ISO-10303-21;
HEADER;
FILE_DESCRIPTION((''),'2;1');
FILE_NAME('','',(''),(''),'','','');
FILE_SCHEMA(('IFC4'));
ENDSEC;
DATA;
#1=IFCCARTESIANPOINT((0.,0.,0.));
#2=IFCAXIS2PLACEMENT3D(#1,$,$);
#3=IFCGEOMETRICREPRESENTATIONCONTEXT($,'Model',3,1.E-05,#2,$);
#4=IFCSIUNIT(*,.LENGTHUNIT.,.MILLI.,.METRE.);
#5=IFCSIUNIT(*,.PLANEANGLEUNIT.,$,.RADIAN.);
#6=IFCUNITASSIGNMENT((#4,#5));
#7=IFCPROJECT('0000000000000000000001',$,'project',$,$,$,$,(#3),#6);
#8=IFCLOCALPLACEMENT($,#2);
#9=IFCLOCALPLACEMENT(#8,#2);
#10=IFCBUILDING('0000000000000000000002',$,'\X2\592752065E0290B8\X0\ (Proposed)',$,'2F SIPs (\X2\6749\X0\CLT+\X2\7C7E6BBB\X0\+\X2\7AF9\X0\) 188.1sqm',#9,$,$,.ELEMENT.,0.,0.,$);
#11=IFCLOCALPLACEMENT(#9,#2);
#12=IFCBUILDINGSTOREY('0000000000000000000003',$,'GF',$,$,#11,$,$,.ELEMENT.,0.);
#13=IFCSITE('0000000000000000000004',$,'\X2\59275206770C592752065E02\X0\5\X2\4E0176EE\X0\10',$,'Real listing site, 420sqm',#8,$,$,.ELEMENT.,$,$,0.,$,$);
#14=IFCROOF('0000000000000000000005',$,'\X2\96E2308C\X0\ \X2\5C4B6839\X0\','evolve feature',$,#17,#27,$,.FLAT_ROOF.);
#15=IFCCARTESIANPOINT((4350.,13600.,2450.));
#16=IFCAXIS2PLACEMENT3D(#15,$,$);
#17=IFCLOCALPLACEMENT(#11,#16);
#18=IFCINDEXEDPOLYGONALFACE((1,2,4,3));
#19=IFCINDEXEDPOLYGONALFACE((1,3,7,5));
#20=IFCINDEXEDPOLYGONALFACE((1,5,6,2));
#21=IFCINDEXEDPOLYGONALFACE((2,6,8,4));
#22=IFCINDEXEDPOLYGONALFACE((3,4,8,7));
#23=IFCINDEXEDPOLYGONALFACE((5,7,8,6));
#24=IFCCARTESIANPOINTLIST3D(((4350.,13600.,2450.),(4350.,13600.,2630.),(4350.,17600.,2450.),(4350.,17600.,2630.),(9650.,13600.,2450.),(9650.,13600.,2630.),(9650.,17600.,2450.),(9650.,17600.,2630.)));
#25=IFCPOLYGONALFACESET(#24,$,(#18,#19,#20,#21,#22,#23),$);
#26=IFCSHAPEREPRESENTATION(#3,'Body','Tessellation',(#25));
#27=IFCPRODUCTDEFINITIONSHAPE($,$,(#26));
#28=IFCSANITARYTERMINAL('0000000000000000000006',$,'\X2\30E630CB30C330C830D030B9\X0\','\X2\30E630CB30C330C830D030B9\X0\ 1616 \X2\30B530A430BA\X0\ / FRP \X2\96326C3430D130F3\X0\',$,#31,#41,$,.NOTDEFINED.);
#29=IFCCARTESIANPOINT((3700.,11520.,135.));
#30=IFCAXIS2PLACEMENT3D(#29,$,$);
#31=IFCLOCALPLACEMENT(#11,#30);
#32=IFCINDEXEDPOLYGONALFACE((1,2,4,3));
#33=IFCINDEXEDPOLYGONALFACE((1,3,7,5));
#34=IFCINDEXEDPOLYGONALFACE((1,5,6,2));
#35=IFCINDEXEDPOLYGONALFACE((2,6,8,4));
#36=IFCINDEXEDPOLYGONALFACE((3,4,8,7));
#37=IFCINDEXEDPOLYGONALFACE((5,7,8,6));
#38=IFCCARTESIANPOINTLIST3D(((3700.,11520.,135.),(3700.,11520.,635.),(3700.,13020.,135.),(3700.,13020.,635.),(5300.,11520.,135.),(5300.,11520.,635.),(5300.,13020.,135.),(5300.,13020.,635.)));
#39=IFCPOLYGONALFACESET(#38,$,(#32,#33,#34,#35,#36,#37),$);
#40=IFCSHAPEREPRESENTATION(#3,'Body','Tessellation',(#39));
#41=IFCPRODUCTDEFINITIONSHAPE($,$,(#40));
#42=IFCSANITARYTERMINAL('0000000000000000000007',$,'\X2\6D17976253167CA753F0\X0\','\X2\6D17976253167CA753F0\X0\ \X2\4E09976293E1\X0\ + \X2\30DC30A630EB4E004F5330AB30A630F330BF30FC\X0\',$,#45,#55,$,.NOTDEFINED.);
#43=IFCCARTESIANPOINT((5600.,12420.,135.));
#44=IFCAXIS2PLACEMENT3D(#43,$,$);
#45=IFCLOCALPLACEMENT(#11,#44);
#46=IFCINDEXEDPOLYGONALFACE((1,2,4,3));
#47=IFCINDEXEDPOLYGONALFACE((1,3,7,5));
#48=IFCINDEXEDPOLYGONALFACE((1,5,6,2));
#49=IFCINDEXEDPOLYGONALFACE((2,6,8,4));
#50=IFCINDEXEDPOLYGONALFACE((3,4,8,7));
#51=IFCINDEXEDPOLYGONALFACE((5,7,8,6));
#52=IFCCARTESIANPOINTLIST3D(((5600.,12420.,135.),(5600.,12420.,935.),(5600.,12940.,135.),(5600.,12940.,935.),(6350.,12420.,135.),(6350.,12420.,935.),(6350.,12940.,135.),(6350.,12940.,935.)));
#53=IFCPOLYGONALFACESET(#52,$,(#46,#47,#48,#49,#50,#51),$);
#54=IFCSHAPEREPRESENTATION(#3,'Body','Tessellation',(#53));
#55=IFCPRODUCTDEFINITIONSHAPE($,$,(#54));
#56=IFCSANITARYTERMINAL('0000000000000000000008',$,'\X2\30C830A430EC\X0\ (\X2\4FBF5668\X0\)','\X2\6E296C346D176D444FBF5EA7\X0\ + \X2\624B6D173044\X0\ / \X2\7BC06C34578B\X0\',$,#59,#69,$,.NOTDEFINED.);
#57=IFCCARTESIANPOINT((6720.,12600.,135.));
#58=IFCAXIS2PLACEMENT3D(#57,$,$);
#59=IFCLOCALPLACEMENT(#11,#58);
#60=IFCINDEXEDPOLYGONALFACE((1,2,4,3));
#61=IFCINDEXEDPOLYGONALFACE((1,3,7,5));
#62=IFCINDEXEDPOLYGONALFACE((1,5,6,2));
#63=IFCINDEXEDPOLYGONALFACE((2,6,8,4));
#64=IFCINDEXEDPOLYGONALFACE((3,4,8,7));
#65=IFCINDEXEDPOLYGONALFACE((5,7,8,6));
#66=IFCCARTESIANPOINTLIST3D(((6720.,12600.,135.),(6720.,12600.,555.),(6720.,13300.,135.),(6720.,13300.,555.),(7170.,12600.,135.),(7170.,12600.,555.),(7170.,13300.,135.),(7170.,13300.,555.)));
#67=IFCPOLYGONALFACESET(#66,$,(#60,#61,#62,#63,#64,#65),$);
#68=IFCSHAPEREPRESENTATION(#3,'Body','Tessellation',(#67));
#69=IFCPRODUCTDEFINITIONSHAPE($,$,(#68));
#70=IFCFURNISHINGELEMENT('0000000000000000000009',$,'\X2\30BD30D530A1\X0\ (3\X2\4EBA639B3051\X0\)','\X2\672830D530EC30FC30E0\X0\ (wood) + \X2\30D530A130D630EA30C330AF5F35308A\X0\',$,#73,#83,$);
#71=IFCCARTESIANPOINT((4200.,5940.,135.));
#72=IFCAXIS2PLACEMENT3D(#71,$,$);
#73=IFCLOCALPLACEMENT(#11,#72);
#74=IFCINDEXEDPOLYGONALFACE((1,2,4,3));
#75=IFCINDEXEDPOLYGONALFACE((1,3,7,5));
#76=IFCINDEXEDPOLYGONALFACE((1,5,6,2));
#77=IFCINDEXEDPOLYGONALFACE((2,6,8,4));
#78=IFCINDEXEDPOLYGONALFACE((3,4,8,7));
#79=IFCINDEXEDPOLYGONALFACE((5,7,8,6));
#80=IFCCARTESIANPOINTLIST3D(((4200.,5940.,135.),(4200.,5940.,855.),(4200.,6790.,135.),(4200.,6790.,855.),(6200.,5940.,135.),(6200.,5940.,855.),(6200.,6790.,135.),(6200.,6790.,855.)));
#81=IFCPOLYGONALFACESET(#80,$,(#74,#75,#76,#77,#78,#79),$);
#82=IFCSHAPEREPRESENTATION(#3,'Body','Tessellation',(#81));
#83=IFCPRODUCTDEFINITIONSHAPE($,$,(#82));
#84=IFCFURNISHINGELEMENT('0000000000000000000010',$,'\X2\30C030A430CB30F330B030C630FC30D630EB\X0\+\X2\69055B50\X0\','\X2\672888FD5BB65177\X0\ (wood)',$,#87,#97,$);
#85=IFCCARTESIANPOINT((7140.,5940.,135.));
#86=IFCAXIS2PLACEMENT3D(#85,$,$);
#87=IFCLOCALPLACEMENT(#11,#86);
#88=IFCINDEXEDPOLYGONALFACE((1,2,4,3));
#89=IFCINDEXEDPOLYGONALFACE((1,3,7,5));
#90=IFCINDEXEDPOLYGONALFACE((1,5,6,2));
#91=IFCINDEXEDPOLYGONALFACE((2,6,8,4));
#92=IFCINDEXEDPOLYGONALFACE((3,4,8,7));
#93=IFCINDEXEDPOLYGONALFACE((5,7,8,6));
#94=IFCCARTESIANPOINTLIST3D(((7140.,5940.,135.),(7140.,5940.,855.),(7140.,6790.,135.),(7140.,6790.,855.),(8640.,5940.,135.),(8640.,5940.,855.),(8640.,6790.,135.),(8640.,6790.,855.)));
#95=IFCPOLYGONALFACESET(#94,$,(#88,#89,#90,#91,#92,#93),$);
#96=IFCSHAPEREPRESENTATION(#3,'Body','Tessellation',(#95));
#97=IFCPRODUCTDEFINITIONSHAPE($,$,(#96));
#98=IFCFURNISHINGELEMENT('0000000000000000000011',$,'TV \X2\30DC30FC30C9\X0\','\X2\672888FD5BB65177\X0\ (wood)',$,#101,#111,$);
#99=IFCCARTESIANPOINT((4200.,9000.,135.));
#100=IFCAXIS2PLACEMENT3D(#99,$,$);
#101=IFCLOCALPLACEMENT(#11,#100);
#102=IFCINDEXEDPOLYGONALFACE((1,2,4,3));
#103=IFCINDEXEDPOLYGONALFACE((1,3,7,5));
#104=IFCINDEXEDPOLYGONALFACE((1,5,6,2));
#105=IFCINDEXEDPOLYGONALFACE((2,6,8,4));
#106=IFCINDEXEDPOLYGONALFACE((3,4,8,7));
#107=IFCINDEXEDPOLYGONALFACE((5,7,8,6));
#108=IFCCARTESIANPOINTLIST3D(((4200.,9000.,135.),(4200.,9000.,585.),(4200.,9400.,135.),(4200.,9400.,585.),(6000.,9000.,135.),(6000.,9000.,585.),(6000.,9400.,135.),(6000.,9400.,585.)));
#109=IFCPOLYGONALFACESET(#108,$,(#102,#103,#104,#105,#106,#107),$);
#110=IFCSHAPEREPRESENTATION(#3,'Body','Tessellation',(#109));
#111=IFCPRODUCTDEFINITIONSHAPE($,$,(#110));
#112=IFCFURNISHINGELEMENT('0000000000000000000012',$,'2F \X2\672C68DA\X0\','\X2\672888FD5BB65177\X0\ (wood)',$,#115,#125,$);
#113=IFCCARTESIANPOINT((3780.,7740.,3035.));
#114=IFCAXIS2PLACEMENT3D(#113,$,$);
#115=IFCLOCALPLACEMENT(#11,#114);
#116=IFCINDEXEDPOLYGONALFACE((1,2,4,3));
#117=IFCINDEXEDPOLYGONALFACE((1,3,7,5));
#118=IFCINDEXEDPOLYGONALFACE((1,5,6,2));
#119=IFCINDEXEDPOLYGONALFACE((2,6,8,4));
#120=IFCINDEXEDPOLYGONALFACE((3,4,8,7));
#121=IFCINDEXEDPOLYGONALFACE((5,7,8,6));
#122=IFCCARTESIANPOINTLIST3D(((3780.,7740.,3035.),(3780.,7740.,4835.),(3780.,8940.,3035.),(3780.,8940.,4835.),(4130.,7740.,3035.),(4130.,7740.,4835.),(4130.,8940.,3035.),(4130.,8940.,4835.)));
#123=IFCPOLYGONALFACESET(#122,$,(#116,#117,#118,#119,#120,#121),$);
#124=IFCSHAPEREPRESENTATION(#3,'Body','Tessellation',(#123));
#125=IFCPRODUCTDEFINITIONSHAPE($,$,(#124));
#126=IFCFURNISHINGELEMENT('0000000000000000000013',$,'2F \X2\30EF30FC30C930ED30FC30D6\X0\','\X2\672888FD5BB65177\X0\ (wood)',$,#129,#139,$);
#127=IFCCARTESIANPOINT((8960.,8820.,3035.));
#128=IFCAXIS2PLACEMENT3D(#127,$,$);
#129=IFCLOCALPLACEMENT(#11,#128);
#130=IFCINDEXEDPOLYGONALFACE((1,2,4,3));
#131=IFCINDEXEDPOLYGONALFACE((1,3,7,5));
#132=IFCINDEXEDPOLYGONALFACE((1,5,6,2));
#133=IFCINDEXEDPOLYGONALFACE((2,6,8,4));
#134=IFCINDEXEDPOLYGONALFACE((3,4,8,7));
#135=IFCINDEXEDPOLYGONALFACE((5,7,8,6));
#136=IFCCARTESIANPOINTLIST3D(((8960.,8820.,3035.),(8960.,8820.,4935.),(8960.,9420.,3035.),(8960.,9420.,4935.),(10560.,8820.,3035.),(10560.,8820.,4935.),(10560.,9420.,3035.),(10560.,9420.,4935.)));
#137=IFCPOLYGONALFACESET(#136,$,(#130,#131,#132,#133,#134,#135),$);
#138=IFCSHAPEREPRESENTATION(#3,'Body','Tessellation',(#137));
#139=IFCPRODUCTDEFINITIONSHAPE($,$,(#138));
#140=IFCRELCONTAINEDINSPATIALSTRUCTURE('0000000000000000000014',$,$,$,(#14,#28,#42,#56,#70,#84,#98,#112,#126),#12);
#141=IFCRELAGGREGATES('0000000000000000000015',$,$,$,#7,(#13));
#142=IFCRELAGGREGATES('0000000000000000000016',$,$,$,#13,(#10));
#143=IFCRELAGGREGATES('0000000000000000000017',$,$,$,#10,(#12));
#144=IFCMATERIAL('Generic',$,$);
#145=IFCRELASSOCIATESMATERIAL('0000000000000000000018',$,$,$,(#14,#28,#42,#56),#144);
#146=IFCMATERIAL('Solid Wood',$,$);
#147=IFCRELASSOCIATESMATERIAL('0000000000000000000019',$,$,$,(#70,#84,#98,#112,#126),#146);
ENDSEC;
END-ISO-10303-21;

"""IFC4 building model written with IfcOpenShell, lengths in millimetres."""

from ifc_helpers import new_model, si_unit, frame, frame_2d, origin, place, context, project, spatial, rectangle, extrude, material, element, save


model = new_model("IFC4")

# Units and contexts
model_context = context("Model", 3, precision=1e-05, world=origin())
ifc_project = project(units=[si_unit("LENGTHUNIT", "METRE", prefix="MILLI"), si_unit("PLANEANGLEUNIT", "RADIAN")], contexts=[model_context])

# Site, building, storey
site_placement = place(None, origin())
site = spatial("IfcSite", under=ifc_project, at=site_placement, Name="大分県大分市5丁目10", ObjectType="Real listing site, 420sqm", CompositionType="ELEMENT", RefElevation=0.0)
building_placement = place(site_placement, origin())
building = spatial("IfcBuilding", under=site, at=building_placement, Name="大分市邸 (Proposed)", ObjectType="2F SIPs (杉CLT+籾殻+竹) 188.1sqm", CompositionType="ELEMENT", ElevationOfRefHeight=0.0, ElevationOfTerrain=0.0)
storey_placement = place(building_placement, origin())
storey = spatial("IfcBuildingStorey", under=building, at=storey_placement, Name="GF", CompositionType="ELEMENT", Elevation=0.0)

# Shared definitions
ifc_material_1 = material(Name="Generic")

# Shared definitions
ifc_material_2 = material(Name="Solid Wood")

# Roof
roof_placement = place(storey_placement, frame((4350.0, 13600.0, 2450.0)))
element("IfcRoof", 1, at=roof_placement, inside=storey, material=ifc_material_1, Name="離れ 屋根", Description="evolve feature", PredefinedType="FLAT_ROOF", context=model_context, shape_type="SweptSolid", body=[
    extrude(rectangle(XDim=5300.0, YDim=4000.0, at=frame_2d((2650.0, 2000.0))), frame((4350.0, 13600.0, 2450.0)), (0.0, 0.0, 1.0), 180.0),
])

# Sanitary terminals
sanitary_terminal_1_placement = place(storey_placement, frame((3700.0, 11520.0, 135.0)))
element("IfcSanitaryTerminal", 2, at=sanitary_terminal_1_placement, inside=storey, material=ifc_material_1, Name="ユニットバス", Description="ユニットバス 1616 サイズ / FRP 防水パン", PredefinedType="NOTDEFINED", context=model_context, shape_type="SweptSolid", body=[
    extrude(rectangle(XDim=1600.0, YDim=1500.0, at=frame_2d((800.0, 750.0))), frame((3700.0, 11520.0, 135.0)), (0.0, 0.0, 1.0), 500.0),
])
sanitary_terminal_2_placement = place(storey_placement, frame((5600.0, 12420.0, 135.0)))
element("IfcSanitaryTerminal", 3, at=sanitary_terminal_2_placement, inside=storey, material=ifc_material_1, Name="洗面化粧台", Description="洗面化粧台 三面鏡 + ボウル一体カウンター", PredefinedType="NOTDEFINED", context=model_context, shape_type="SweptSolid", body=[
    extrude(rectangle(XDim=750.0, YDim=520.0, at=frame_2d((375.0, 260.0))), frame((5600.0, 12420.0, 135.0)), (0.0, 0.0, 1.0), 800.0),
])
sanitary_terminal_3_placement = place(storey_placement, frame((6720.0, 12600.0, 135.0)))
element("IfcSanitaryTerminal", 4, at=sanitary_terminal_3_placement, inside=storey, material=ifc_material_1, Name="トイレ (便器)", Description="温水洗浄便座 + 手洗い / 節水型", PredefinedType="NOTDEFINED", context=model_context, shape_type="SweptSolid", body=[
    extrude(rectangle(XDim=450.0, YDim=700.0, at=frame_2d((225.0, 350.0))), frame((6720.0, 12600.0, 135.0)), (0.0, 0.0, 1.0), 420.0),
])

# Furnishing elements
furnishing_1_placement = place(storey_placement, frame((4200.0, 5940.0, 135.0)))
element("IfcFurnishingElement", 5, at=furnishing_1_placement, inside=storey, material=ifc_material_2, Name="ソファ (3人掛け)", Description="木フレーム (wood) + ファブリック張り", context=model_context, shape_type="SweptSolid", body=[
    extrude(rectangle(XDim=2000.0, YDim=850.0, at=frame_2d((1000.0, 425.0))), frame((4200.0, 5940.0, 135.0)), (0.0, 0.0, 1.0), 720.0),
])
furnishing_2_placement = place(storey_placement, frame((7140.0, 5940.0, 135.0)))
element("IfcFurnishingElement", 6, at=furnishing_2_placement, inside=storey, material=ifc_material_2, Name="ダイニングテーブル+椅子", Description="木製家具 (wood)", context=model_context, shape_type="SweptSolid", body=[
    extrude(rectangle(XDim=1500.0, YDim=850.0, at=frame_2d((750.0, 425.0))), frame((7140.0, 5940.0, 135.0)), (0.0, 0.0, 1.0), 720.0),
])
furnishing_3_placement = place(storey_placement, frame((4200.0, 9000.0, 135.0)))
element("IfcFurnishingElement", 7, at=furnishing_3_placement, inside=storey, material=ifc_material_2, Name="TV ボード", Description="木製家具 (wood)", context=model_context, shape_type="SweptSolid", body=[
    extrude(rectangle(XDim=1800.0, YDim=400.0, at=frame_2d((900.0, 200.0))), frame((4200.0, 9000.0, 135.0)), (0.0, 0.0, 1.0), 450.0),
])
furnishing_4_placement = place(storey_placement, frame((3780.0, 7740.0, 3035.0)))
element("IfcFurnishingElement", 8, at=furnishing_4_placement, inside=storey, material=ifc_material_2, Name="2F 本棚", Description="木製家具 (wood)", context=model_context, shape_type="SweptSolid", body=[
    extrude(rectangle(XDim=350.0, YDim=1200.0, at=frame_2d((175.0, 600.0))), frame((3780.0, 7740.0, 3035.0)), (0.0, 0.0, 1.0), 1800.0),
])
furnishing_5_placement = place(storey_placement, frame((8960.0, 8820.0, 3035.0)))
element("IfcFurnishingElement", 9, at=furnishing_5_placement, inside=storey, material=ifc_material_2, Name="2F ワードローブ", Description="木製家具 (wood)", context=model_context, shape_type="SweptSolid", body=[
    extrude(rectangle(XDim=1600.0, YDim=600.0, at=frame_2d((800.0, 300.0))), frame((8960.0, 8820.0, 3035.0)), (0.0, 0.0, 1.0), 1900.0),
])

save(model, "model.ifc")
